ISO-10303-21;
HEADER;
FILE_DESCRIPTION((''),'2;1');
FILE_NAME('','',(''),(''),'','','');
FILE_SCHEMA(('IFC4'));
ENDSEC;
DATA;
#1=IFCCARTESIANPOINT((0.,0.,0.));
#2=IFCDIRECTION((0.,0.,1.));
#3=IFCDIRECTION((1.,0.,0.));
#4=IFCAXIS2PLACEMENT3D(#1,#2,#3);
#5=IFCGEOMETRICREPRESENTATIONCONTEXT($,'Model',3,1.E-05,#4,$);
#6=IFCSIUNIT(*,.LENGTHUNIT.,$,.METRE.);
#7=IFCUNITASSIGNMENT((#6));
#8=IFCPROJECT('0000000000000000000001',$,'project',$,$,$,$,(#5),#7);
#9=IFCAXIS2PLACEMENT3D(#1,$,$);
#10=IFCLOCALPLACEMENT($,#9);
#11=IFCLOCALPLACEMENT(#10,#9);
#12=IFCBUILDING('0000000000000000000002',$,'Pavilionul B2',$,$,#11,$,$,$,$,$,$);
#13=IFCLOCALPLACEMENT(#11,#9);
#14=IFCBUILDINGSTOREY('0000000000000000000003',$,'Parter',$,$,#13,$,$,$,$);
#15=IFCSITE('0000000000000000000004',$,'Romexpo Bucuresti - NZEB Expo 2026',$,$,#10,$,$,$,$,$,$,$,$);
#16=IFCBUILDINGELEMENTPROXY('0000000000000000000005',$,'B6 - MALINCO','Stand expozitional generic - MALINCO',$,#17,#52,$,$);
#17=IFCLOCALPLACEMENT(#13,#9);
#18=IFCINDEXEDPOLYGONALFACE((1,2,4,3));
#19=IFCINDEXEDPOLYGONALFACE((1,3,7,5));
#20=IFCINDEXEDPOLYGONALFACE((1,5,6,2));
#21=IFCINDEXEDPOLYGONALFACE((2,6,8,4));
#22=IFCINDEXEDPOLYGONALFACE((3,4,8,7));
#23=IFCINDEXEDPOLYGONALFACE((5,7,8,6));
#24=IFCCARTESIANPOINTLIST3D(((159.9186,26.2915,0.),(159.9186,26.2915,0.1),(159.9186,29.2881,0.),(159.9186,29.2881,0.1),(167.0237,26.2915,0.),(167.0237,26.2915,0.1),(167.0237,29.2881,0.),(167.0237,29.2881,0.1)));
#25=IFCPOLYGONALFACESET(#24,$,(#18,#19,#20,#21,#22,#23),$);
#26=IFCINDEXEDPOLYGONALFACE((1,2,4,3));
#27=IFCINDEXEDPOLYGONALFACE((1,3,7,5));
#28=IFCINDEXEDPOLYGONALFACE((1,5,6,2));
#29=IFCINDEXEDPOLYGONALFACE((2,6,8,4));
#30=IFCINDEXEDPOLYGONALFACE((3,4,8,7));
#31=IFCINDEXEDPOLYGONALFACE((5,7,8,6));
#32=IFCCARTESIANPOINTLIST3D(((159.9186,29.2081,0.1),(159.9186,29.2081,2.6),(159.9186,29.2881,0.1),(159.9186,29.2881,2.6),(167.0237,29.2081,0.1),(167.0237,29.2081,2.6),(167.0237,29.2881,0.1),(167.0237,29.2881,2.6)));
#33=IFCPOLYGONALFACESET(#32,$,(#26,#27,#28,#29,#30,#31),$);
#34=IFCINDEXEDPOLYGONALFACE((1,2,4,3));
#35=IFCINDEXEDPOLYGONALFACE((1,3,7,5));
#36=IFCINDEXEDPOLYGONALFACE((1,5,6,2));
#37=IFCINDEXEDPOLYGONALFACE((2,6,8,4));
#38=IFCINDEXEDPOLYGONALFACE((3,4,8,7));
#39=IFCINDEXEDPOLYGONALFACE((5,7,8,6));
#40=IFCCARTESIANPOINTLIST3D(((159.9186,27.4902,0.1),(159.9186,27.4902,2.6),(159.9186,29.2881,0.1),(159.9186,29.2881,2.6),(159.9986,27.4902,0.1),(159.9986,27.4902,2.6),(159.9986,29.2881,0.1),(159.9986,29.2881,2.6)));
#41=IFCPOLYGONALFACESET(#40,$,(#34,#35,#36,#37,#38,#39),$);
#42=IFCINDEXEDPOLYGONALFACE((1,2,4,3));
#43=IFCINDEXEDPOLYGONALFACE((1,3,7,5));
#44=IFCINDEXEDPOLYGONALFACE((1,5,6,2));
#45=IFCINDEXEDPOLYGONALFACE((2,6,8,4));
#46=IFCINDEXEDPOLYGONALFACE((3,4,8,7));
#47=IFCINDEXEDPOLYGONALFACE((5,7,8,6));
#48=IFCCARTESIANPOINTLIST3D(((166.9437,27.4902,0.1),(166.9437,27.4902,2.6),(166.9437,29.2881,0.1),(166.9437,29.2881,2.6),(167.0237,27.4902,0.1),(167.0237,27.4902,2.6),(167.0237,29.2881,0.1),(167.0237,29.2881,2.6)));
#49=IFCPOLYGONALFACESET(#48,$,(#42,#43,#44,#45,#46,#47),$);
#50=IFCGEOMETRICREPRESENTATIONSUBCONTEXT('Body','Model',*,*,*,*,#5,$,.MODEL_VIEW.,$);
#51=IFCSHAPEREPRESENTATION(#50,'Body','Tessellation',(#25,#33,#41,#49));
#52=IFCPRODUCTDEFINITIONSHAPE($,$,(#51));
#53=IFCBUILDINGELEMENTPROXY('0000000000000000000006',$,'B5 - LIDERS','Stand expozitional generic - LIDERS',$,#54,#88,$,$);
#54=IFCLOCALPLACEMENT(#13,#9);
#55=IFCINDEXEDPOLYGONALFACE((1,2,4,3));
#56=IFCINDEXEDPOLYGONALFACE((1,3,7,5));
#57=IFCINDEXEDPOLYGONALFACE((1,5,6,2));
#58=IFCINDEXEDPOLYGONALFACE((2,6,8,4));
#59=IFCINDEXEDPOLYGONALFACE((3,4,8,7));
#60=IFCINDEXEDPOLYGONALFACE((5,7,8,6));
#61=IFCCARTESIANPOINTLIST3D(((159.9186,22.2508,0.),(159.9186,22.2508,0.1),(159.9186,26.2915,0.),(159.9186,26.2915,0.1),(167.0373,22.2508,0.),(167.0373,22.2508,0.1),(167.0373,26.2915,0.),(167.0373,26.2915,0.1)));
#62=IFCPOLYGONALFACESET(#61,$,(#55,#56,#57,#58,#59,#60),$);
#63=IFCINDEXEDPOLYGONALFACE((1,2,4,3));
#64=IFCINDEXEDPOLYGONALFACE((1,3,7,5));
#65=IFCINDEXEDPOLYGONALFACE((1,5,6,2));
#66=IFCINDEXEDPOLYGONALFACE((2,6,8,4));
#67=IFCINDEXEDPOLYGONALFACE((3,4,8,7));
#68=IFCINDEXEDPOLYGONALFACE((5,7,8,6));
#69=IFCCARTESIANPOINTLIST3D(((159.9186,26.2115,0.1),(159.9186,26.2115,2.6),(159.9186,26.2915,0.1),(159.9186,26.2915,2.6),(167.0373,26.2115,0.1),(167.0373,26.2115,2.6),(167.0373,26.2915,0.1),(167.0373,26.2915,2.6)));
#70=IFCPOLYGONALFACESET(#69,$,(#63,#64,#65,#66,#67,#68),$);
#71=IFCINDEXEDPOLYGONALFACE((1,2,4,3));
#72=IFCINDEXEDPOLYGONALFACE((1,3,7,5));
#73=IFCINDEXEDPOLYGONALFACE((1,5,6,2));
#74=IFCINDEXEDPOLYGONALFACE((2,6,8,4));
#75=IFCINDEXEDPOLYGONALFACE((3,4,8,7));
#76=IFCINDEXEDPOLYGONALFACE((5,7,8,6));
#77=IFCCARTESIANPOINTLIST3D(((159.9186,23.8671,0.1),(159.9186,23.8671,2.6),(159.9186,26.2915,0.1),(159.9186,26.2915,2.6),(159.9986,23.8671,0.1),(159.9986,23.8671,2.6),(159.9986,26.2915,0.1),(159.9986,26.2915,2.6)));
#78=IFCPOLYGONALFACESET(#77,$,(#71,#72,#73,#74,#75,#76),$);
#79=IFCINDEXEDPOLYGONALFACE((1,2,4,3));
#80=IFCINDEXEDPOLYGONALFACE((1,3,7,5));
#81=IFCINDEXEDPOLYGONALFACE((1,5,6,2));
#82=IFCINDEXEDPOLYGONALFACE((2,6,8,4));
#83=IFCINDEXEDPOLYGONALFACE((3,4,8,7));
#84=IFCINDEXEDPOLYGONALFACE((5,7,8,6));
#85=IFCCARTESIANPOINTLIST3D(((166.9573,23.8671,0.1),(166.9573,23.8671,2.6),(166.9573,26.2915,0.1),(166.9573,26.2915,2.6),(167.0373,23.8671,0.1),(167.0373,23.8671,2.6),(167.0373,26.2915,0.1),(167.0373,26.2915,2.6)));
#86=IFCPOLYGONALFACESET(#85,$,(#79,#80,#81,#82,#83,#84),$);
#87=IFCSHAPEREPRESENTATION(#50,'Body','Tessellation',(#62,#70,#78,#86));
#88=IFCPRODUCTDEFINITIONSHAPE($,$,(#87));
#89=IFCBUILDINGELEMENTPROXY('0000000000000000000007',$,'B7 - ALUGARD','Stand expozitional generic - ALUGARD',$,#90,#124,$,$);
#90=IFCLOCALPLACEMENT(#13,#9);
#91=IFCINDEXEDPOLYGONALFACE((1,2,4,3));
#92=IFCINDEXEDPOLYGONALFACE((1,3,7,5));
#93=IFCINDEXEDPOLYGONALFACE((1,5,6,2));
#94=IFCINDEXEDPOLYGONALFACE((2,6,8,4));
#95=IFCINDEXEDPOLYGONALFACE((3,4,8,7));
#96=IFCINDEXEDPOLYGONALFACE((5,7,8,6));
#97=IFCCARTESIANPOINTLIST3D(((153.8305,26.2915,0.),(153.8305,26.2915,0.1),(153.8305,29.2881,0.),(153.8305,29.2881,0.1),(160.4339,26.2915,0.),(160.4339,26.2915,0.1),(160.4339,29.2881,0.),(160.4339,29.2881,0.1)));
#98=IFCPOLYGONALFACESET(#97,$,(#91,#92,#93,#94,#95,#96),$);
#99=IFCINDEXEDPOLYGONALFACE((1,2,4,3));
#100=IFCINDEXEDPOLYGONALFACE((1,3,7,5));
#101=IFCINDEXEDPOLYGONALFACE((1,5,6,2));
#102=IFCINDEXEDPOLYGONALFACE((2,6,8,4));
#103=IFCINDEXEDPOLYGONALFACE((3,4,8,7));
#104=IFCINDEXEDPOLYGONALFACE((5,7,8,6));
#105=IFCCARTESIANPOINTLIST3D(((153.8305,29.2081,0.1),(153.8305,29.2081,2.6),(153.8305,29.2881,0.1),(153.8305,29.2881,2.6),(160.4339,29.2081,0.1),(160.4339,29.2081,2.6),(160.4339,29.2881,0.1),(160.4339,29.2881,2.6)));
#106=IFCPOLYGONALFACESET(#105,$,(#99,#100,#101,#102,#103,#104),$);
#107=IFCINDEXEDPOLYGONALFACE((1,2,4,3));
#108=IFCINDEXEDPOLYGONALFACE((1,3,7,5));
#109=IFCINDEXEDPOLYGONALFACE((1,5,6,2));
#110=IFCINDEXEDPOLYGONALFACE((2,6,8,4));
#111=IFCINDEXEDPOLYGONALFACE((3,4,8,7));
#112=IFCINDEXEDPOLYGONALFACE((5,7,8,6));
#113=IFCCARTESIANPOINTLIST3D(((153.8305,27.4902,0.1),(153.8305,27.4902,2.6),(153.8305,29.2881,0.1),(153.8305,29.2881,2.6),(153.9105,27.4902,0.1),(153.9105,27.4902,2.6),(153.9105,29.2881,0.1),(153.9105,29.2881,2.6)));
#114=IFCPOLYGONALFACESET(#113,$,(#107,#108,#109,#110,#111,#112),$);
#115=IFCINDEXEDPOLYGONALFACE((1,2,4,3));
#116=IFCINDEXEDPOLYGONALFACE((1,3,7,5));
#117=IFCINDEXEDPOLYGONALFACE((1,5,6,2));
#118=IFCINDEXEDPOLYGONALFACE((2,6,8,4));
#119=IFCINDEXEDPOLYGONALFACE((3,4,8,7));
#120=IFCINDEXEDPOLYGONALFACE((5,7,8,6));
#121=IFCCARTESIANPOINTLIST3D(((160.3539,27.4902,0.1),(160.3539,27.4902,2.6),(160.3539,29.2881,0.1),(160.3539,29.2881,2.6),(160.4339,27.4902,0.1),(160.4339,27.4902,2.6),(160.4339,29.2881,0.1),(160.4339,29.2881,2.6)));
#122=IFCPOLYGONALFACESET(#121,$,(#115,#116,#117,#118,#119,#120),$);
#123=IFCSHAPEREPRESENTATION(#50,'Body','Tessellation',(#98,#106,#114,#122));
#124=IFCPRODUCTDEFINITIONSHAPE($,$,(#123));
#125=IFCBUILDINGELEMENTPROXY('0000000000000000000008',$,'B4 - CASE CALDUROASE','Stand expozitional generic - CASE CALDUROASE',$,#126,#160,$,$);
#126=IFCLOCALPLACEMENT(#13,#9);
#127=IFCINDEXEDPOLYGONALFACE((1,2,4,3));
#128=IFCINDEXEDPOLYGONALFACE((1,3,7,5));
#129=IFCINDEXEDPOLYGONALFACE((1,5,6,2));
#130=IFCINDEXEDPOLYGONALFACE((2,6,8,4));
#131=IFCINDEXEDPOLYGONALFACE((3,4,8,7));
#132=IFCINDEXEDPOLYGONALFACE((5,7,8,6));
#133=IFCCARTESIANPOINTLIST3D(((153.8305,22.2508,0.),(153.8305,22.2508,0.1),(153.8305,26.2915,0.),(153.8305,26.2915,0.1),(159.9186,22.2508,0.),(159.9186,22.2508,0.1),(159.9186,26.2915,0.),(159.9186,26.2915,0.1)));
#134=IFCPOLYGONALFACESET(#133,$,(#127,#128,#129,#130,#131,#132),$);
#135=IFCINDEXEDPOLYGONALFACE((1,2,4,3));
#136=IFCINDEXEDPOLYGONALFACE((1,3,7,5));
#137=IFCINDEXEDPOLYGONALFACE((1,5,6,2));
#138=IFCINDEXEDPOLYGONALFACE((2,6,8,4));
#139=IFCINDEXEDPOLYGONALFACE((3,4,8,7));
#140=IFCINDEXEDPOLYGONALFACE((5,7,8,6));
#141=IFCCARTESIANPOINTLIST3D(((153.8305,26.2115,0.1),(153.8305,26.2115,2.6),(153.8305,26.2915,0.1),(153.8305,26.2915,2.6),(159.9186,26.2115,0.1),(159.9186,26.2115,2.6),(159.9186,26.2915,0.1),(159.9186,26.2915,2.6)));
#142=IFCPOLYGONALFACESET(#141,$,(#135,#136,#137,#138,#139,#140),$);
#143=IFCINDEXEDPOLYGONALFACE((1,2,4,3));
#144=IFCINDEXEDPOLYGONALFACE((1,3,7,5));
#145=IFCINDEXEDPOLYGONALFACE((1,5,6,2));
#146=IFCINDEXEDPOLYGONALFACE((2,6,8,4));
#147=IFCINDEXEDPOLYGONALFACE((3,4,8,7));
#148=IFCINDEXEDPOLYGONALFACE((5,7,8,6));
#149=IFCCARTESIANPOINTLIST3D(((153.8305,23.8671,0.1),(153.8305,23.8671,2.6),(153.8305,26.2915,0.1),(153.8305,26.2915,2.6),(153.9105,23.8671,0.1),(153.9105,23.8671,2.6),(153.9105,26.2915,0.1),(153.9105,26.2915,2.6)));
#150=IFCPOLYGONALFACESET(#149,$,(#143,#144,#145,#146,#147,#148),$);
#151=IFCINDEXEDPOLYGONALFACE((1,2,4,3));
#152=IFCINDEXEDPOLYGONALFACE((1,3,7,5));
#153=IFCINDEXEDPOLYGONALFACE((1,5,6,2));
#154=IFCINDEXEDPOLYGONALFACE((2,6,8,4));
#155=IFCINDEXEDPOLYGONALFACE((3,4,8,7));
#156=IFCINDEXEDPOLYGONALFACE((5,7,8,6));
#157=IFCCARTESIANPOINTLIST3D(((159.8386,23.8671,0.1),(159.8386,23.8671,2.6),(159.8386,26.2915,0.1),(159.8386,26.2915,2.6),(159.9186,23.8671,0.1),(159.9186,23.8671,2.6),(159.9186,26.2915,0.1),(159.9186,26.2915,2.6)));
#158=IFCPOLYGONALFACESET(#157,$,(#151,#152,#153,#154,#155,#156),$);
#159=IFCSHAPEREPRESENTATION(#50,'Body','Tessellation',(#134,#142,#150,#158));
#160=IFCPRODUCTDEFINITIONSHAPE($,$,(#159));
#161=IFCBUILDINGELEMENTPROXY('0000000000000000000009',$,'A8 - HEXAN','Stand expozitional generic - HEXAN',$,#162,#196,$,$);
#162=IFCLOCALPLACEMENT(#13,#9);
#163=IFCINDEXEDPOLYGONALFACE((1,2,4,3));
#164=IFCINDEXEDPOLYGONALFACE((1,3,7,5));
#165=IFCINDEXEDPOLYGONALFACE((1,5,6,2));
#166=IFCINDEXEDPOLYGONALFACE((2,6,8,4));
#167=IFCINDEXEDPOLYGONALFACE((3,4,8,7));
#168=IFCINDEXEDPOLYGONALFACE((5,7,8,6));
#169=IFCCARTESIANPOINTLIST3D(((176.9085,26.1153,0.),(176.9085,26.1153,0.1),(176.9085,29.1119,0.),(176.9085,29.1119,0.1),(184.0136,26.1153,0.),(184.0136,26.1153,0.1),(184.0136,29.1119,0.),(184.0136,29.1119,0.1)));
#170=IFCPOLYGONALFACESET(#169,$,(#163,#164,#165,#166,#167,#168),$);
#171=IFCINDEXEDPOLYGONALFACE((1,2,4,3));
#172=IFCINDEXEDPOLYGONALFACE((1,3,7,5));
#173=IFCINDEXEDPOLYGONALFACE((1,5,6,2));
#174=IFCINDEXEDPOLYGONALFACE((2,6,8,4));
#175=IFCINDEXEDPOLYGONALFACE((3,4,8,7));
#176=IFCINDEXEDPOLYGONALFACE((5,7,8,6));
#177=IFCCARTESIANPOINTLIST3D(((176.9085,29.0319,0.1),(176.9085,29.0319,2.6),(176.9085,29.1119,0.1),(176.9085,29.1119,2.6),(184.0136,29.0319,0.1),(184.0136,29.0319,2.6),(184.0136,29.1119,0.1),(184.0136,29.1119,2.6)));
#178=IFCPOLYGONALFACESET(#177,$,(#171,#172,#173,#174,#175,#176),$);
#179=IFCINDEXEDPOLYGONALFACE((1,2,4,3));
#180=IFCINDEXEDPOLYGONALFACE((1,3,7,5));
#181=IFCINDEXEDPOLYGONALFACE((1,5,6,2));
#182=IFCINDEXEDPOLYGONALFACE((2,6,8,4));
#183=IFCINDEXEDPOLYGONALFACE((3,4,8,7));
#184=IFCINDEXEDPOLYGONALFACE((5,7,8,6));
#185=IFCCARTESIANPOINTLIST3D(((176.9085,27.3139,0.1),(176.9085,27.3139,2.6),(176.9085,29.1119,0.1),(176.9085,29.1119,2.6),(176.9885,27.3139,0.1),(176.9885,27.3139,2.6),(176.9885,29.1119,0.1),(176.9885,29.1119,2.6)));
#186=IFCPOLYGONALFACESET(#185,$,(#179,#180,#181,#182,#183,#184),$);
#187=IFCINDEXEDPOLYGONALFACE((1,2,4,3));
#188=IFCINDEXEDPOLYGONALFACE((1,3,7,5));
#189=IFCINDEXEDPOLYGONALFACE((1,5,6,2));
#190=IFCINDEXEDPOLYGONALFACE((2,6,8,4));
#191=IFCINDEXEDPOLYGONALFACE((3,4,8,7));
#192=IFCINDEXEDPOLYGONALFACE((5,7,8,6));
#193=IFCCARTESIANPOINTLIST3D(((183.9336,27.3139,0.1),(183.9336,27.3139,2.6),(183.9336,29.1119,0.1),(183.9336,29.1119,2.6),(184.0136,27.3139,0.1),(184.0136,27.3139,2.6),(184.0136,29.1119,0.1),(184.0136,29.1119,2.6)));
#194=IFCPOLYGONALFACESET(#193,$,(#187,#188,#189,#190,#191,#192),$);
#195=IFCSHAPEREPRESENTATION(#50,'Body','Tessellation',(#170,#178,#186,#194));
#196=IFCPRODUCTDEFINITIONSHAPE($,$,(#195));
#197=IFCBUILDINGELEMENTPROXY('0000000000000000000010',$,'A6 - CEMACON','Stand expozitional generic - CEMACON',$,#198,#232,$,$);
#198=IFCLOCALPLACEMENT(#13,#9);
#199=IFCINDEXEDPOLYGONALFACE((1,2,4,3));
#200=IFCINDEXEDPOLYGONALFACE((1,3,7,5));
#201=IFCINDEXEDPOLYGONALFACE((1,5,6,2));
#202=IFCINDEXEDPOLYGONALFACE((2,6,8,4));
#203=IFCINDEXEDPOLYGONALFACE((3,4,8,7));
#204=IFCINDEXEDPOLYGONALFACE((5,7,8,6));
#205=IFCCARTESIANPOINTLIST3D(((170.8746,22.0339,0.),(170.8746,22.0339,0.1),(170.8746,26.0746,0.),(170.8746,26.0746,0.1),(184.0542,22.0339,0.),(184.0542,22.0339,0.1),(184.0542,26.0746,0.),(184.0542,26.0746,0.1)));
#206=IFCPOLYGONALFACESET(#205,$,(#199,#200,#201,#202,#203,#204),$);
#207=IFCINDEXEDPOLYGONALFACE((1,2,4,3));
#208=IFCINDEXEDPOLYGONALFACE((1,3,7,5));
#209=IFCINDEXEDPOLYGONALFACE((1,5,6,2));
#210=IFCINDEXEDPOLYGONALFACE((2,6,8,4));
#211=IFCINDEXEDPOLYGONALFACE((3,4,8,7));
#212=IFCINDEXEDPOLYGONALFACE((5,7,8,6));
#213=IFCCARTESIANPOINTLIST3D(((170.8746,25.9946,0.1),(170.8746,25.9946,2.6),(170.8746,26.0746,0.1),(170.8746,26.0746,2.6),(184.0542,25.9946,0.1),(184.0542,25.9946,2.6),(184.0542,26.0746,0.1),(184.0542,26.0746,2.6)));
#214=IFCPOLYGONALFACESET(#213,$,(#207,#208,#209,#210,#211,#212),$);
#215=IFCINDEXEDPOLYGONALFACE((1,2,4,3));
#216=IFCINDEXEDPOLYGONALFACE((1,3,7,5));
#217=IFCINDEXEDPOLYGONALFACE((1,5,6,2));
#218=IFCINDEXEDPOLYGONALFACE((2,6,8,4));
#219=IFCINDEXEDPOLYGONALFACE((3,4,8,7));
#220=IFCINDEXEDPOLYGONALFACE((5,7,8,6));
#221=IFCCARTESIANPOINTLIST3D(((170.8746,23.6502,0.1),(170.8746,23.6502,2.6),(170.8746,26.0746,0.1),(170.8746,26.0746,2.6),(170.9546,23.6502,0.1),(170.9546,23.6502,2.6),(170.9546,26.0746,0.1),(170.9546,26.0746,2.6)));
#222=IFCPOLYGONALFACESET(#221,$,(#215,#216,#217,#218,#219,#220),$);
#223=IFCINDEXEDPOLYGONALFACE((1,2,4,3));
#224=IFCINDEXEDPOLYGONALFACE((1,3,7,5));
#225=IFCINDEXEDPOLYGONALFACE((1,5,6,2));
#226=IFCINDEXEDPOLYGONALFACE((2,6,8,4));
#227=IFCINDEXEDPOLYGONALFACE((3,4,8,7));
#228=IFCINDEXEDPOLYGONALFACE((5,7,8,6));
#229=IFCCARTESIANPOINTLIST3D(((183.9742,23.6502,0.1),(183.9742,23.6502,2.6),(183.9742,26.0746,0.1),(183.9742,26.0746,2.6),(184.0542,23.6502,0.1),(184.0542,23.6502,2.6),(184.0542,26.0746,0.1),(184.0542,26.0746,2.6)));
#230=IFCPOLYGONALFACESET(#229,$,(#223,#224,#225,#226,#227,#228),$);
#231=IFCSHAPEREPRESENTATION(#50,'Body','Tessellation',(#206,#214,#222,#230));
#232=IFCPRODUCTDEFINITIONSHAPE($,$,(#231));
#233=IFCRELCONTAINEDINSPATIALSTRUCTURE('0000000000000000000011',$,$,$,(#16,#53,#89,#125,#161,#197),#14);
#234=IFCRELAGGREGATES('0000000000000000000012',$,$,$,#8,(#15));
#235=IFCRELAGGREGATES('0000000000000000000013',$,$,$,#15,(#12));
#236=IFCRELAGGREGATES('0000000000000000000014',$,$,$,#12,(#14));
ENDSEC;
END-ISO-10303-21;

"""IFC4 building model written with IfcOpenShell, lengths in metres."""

from ifc_helpers import new_model, si_unit, frame, frame_2d, origin, origin_with_axes, place, context, subcontext, project, spatial, rectangle, extrude, element, save


model = new_model("IFC4")

# Units and contexts
model_context = context("Model", 3, precision=1e-05, world=origin_with_axes())
body_context = subcontext(model_context, "Body", "Model", "MODEL_VIEW")
ifc_project = project(units=[si_unit("LENGTHUNIT", "METRE")], contexts=[model_context])

# Site, building, storey
site_placement = place(None, origin())
site = spatial("IfcSite", under=ifc_project, at=site_placement, Name="Romexpo Bucuresti - NZEB Expo 2026")
building_placement = place(site_placement, origin())
building = spatial("IfcBuilding", under=site, at=building_placement, Name="Pavilionul B2")
storey_placement = place(building_placement, origin())
storey = spatial("IfcBuildingStorey", under=building, at=storey_placement, Name="Parter")

# Building element proxies
proxy_1_placement = place(storey_placement, frame((159.9186, 26.2915, 0.0), z_axis=(0.0, 0.0, 1.0), x_axis=(1.0, 0.0, 0.0)))
element("IfcBuildingElementProxy", 1, at=proxy_1_placement, inside=storey, Name="B6 - MALINCO", Description="Stand expozitional generic - MALINCO", context=body_context, shape_type="SweptSolid", body=[
    extrude(rectangle(XDim=7.1051, YDim=2.9966, at=frame_2d((3.5525, 1.4983))), origin(), (0.0, 0.0, 1.0), 0.1),
    extrude(rectangle(XDim=7.1051, YDim=0.08, at=frame_2d((3.5525, 2.9566))), frame((0.0, 0.0, 0.1)), (0.0, 0.0, 1.0), 2.5),
    extrude(rectangle(XDim=0.08, YDim=1.798, at=frame_2d((0.04, 2.0976))), frame((0.0, 0.0, 0.1)), (0.0, 0.0, 1.0), 2.5),
    extrude(rectangle(XDim=0.08, YDim=1.798, at=frame_2d((7.0651, 2.0976))), frame((0.0, 0.0, 0.1)), (0.0, 0.0, 1.0), 2.5),
])
proxy_2_placement = place(storey_placement, frame((159.9186, 22.2508, 0.0), z_axis=(0.0, 0.0, 1.0), x_axis=(1.0, 0.0, 0.0)))
element("IfcBuildingElementProxy", 2, at=proxy_2_placement, inside=storey, Name="B5 - LIDERS", Description="Stand expozitional generic - LIDERS", context=body_context, shape_type="SweptSolid", body=[
    extrude(rectangle(XDim=7.1186, YDim=4.0407, at=frame_2d((3.5593, 2.0203))), origin(), (0.0, 0.0, 1.0), 0.1),
    extrude(rectangle(XDim=7.1186, YDim=0.08, at=frame_2d((3.5593, 4.0007))), frame((0.0, 0.0, 0.1)), (0.0, 0.0, 1.0), 2.5),
    extrude(rectangle(XDim=0.08, YDim=2.4244, at=frame_2d((0.04, 2.8285))), frame((0.0, 0.0, 0.1)), (0.0, 0.0, 1.0), 2.5),
    extrude(rectangle(XDim=0.08, YDim=2.4244, at=frame_2d((7.0786, 2.8285))), frame((0.0, 0.0, 0.1)), (0.0, 0.0, 1.0), 2.5),
])
proxy_3_placement = place(storey_placement, frame((153.8305, 26.2915, 0.0), z_axis=(0.0, 0.0, 1.0), x_axis=(1.0, 0.0, 0.0)))
element("IfcBuildingElementProxy", 3, at=proxy_3_placement, inside=storey, Name="B7 - ALUGARD", Description="Stand expozitional generic - ALUGARD", context=body_context, shape_type="SweptSolid", body=[
    extrude(rectangle(XDim=6.6034, YDim=2.9966, at=frame_2d((3.3017, 1.4983))), origin(), (0.0, 0.0, 1.0), 0.1),
    extrude(rectangle(XDim=6.6034, YDim=0.08, at=frame_2d((3.3017, 2.9566))), frame((0.0, 0.0, 0.1)), (0.0, 0.0, 1.0), 2.5),
    extrude(rectangle(XDim=0.08, YDim=1.798, at=frame_2d((0.04, 2.0976))), frame((0.0, 0.0, 0.1)), (0.0, 0.0, 1.0), 2.5),
    extrude(rectangle(XDim=0.08, YDim=1.798, at=frame_2d((6.5634, 2.0976))), frame((0.0, 0.0, 0.1)), (0.0, 0.0, 1.0), 2.5),
])
proxy_4_placement = place(storey_placement, frame((153.8305, 22.2508, 0.0), z_axis=(0.0, 0.0, 1.0), x_axis=(1.0, 0.0, 0.0)))
element("IfcBuildingElementProxy", 4, at=proxy_4_placement, inside=storey, Name="B4 - CASE CALDUROASE", Description="Stand expozitional generic - CASE CALDUROASE", context=body_context, shape_type="SweptSolid", body=[
    extrude(rectangle(XDim=6.0881, YDim=4.0407, at=frame_2d((3.0441, 2.0203))), origin(), (0.0, 0.0, 1.0), 0.1),
    extrude(rectangle(XDim=6.0881, YDim=0.08, at=frame_2d((3.0441, 4.0007))), frame((0.0, 0.0, 0.1)), (0.0, 0.0, 1.0), 2.5),
    extrude(rectangle(XDim=0.08, YDim=2.4244, at=frame_2d((0.04, 2.8285))), frame((0.0, 0.0, 0.1)), (0.0, 0.0, 1.0), 2.5),
    extrude(rectangle(XDim=0.08, YDim=2.4244, at=frame_2d((6.0481, 2.8285))), frame((0.0, 0.0, 0.1)), (0.0, 0.0, 1.0), 2.5),
])
proxy_5_placement = place(storey_placement, frame((176.9085, 26.1153, 0.0), z_axis=(0.0, 0.0, 1.0), x_axis=(1.0, 0.0, 0.0)))
element("IfcBuildingElementProxy", 5, at=proxy_5_placement, inside=storey, Name="A8 - HEXAN", Description="Stand expozitional generic - HEXAN", context=body_context, shape_type="SweptSolid", body=[
    extrude(rectangle(XDim=7.1051, YDim=2.9966, at=frame_2d((3.5525, 1.4983))), origin(), (0.0, 0.0, 1.0), 0.1),
    extrude(rectangle(XDim=7.1051, YDim=0.08, at=frame_2d((3.5525, 2.9566))), frame((0.0, 0.0, 0.1)), (0.0, 0.0, 1.0), 2.5),
    extrude(rectangle(XDim=0.08, YDim=1.798, at=frame_2d((0.04, 2.0976))), frame((0.0, 0.0, 0.1)), (0.0, 0.0, 1.0), 2.5),
    extrude(rectangle(XDim=0.08, YDim=1.798, at=frame_2d((7.0651, 2.0976))), frame((0.0, 0.0, 0.1)), (0.0, 0.0, 1.0), 2.5),
])
proxy_6_placement = place(storey_placement, frame((170.8746, 22.0339, 0.0), z_axis=(0.0, 0.0, 1.0), x_axis=(1.0, 0.0, 0.0)))
element("IfcBuildingElementProxy", 6, at=proxy_6_placement, inside=storey, Name="A6 - CEMACON", Description="Stand expozitional generic - CEMACON", context=body_context, shape_type="SweptSolid", body=[
    extrude(rectangle(XDim=13.1797, YDim=4.0407, at=frame_2d((6.5898, 2.0203))), origin(), (0.0, 0.0, 1.0), 0.1),
    extrude(rectangle(XDim=13.1797, YDim=0.08, at=frame_2d((6.5898, 4.0007))), frame((0.0, 0.0, 0.1)), (0.0, 0.0, 1.0), 2.5),
    extrude(rectangle(XDim=0.08, YDim=2.4244, at=frame_2d((0.04, 2.8285))), frame((0.0, 0.0, 0.1)), (0.0, 0.0, 1.0), 2.5),
    extrude(rectangle(XDim=0.08, YDim=2.4244, at=frame_2d((13.1397, 2.8285))), frame((0.0, 0.0, 0.1)), (0.0, 0.0, 1.0), 2.5),
])

save(model, "model.ifc")
